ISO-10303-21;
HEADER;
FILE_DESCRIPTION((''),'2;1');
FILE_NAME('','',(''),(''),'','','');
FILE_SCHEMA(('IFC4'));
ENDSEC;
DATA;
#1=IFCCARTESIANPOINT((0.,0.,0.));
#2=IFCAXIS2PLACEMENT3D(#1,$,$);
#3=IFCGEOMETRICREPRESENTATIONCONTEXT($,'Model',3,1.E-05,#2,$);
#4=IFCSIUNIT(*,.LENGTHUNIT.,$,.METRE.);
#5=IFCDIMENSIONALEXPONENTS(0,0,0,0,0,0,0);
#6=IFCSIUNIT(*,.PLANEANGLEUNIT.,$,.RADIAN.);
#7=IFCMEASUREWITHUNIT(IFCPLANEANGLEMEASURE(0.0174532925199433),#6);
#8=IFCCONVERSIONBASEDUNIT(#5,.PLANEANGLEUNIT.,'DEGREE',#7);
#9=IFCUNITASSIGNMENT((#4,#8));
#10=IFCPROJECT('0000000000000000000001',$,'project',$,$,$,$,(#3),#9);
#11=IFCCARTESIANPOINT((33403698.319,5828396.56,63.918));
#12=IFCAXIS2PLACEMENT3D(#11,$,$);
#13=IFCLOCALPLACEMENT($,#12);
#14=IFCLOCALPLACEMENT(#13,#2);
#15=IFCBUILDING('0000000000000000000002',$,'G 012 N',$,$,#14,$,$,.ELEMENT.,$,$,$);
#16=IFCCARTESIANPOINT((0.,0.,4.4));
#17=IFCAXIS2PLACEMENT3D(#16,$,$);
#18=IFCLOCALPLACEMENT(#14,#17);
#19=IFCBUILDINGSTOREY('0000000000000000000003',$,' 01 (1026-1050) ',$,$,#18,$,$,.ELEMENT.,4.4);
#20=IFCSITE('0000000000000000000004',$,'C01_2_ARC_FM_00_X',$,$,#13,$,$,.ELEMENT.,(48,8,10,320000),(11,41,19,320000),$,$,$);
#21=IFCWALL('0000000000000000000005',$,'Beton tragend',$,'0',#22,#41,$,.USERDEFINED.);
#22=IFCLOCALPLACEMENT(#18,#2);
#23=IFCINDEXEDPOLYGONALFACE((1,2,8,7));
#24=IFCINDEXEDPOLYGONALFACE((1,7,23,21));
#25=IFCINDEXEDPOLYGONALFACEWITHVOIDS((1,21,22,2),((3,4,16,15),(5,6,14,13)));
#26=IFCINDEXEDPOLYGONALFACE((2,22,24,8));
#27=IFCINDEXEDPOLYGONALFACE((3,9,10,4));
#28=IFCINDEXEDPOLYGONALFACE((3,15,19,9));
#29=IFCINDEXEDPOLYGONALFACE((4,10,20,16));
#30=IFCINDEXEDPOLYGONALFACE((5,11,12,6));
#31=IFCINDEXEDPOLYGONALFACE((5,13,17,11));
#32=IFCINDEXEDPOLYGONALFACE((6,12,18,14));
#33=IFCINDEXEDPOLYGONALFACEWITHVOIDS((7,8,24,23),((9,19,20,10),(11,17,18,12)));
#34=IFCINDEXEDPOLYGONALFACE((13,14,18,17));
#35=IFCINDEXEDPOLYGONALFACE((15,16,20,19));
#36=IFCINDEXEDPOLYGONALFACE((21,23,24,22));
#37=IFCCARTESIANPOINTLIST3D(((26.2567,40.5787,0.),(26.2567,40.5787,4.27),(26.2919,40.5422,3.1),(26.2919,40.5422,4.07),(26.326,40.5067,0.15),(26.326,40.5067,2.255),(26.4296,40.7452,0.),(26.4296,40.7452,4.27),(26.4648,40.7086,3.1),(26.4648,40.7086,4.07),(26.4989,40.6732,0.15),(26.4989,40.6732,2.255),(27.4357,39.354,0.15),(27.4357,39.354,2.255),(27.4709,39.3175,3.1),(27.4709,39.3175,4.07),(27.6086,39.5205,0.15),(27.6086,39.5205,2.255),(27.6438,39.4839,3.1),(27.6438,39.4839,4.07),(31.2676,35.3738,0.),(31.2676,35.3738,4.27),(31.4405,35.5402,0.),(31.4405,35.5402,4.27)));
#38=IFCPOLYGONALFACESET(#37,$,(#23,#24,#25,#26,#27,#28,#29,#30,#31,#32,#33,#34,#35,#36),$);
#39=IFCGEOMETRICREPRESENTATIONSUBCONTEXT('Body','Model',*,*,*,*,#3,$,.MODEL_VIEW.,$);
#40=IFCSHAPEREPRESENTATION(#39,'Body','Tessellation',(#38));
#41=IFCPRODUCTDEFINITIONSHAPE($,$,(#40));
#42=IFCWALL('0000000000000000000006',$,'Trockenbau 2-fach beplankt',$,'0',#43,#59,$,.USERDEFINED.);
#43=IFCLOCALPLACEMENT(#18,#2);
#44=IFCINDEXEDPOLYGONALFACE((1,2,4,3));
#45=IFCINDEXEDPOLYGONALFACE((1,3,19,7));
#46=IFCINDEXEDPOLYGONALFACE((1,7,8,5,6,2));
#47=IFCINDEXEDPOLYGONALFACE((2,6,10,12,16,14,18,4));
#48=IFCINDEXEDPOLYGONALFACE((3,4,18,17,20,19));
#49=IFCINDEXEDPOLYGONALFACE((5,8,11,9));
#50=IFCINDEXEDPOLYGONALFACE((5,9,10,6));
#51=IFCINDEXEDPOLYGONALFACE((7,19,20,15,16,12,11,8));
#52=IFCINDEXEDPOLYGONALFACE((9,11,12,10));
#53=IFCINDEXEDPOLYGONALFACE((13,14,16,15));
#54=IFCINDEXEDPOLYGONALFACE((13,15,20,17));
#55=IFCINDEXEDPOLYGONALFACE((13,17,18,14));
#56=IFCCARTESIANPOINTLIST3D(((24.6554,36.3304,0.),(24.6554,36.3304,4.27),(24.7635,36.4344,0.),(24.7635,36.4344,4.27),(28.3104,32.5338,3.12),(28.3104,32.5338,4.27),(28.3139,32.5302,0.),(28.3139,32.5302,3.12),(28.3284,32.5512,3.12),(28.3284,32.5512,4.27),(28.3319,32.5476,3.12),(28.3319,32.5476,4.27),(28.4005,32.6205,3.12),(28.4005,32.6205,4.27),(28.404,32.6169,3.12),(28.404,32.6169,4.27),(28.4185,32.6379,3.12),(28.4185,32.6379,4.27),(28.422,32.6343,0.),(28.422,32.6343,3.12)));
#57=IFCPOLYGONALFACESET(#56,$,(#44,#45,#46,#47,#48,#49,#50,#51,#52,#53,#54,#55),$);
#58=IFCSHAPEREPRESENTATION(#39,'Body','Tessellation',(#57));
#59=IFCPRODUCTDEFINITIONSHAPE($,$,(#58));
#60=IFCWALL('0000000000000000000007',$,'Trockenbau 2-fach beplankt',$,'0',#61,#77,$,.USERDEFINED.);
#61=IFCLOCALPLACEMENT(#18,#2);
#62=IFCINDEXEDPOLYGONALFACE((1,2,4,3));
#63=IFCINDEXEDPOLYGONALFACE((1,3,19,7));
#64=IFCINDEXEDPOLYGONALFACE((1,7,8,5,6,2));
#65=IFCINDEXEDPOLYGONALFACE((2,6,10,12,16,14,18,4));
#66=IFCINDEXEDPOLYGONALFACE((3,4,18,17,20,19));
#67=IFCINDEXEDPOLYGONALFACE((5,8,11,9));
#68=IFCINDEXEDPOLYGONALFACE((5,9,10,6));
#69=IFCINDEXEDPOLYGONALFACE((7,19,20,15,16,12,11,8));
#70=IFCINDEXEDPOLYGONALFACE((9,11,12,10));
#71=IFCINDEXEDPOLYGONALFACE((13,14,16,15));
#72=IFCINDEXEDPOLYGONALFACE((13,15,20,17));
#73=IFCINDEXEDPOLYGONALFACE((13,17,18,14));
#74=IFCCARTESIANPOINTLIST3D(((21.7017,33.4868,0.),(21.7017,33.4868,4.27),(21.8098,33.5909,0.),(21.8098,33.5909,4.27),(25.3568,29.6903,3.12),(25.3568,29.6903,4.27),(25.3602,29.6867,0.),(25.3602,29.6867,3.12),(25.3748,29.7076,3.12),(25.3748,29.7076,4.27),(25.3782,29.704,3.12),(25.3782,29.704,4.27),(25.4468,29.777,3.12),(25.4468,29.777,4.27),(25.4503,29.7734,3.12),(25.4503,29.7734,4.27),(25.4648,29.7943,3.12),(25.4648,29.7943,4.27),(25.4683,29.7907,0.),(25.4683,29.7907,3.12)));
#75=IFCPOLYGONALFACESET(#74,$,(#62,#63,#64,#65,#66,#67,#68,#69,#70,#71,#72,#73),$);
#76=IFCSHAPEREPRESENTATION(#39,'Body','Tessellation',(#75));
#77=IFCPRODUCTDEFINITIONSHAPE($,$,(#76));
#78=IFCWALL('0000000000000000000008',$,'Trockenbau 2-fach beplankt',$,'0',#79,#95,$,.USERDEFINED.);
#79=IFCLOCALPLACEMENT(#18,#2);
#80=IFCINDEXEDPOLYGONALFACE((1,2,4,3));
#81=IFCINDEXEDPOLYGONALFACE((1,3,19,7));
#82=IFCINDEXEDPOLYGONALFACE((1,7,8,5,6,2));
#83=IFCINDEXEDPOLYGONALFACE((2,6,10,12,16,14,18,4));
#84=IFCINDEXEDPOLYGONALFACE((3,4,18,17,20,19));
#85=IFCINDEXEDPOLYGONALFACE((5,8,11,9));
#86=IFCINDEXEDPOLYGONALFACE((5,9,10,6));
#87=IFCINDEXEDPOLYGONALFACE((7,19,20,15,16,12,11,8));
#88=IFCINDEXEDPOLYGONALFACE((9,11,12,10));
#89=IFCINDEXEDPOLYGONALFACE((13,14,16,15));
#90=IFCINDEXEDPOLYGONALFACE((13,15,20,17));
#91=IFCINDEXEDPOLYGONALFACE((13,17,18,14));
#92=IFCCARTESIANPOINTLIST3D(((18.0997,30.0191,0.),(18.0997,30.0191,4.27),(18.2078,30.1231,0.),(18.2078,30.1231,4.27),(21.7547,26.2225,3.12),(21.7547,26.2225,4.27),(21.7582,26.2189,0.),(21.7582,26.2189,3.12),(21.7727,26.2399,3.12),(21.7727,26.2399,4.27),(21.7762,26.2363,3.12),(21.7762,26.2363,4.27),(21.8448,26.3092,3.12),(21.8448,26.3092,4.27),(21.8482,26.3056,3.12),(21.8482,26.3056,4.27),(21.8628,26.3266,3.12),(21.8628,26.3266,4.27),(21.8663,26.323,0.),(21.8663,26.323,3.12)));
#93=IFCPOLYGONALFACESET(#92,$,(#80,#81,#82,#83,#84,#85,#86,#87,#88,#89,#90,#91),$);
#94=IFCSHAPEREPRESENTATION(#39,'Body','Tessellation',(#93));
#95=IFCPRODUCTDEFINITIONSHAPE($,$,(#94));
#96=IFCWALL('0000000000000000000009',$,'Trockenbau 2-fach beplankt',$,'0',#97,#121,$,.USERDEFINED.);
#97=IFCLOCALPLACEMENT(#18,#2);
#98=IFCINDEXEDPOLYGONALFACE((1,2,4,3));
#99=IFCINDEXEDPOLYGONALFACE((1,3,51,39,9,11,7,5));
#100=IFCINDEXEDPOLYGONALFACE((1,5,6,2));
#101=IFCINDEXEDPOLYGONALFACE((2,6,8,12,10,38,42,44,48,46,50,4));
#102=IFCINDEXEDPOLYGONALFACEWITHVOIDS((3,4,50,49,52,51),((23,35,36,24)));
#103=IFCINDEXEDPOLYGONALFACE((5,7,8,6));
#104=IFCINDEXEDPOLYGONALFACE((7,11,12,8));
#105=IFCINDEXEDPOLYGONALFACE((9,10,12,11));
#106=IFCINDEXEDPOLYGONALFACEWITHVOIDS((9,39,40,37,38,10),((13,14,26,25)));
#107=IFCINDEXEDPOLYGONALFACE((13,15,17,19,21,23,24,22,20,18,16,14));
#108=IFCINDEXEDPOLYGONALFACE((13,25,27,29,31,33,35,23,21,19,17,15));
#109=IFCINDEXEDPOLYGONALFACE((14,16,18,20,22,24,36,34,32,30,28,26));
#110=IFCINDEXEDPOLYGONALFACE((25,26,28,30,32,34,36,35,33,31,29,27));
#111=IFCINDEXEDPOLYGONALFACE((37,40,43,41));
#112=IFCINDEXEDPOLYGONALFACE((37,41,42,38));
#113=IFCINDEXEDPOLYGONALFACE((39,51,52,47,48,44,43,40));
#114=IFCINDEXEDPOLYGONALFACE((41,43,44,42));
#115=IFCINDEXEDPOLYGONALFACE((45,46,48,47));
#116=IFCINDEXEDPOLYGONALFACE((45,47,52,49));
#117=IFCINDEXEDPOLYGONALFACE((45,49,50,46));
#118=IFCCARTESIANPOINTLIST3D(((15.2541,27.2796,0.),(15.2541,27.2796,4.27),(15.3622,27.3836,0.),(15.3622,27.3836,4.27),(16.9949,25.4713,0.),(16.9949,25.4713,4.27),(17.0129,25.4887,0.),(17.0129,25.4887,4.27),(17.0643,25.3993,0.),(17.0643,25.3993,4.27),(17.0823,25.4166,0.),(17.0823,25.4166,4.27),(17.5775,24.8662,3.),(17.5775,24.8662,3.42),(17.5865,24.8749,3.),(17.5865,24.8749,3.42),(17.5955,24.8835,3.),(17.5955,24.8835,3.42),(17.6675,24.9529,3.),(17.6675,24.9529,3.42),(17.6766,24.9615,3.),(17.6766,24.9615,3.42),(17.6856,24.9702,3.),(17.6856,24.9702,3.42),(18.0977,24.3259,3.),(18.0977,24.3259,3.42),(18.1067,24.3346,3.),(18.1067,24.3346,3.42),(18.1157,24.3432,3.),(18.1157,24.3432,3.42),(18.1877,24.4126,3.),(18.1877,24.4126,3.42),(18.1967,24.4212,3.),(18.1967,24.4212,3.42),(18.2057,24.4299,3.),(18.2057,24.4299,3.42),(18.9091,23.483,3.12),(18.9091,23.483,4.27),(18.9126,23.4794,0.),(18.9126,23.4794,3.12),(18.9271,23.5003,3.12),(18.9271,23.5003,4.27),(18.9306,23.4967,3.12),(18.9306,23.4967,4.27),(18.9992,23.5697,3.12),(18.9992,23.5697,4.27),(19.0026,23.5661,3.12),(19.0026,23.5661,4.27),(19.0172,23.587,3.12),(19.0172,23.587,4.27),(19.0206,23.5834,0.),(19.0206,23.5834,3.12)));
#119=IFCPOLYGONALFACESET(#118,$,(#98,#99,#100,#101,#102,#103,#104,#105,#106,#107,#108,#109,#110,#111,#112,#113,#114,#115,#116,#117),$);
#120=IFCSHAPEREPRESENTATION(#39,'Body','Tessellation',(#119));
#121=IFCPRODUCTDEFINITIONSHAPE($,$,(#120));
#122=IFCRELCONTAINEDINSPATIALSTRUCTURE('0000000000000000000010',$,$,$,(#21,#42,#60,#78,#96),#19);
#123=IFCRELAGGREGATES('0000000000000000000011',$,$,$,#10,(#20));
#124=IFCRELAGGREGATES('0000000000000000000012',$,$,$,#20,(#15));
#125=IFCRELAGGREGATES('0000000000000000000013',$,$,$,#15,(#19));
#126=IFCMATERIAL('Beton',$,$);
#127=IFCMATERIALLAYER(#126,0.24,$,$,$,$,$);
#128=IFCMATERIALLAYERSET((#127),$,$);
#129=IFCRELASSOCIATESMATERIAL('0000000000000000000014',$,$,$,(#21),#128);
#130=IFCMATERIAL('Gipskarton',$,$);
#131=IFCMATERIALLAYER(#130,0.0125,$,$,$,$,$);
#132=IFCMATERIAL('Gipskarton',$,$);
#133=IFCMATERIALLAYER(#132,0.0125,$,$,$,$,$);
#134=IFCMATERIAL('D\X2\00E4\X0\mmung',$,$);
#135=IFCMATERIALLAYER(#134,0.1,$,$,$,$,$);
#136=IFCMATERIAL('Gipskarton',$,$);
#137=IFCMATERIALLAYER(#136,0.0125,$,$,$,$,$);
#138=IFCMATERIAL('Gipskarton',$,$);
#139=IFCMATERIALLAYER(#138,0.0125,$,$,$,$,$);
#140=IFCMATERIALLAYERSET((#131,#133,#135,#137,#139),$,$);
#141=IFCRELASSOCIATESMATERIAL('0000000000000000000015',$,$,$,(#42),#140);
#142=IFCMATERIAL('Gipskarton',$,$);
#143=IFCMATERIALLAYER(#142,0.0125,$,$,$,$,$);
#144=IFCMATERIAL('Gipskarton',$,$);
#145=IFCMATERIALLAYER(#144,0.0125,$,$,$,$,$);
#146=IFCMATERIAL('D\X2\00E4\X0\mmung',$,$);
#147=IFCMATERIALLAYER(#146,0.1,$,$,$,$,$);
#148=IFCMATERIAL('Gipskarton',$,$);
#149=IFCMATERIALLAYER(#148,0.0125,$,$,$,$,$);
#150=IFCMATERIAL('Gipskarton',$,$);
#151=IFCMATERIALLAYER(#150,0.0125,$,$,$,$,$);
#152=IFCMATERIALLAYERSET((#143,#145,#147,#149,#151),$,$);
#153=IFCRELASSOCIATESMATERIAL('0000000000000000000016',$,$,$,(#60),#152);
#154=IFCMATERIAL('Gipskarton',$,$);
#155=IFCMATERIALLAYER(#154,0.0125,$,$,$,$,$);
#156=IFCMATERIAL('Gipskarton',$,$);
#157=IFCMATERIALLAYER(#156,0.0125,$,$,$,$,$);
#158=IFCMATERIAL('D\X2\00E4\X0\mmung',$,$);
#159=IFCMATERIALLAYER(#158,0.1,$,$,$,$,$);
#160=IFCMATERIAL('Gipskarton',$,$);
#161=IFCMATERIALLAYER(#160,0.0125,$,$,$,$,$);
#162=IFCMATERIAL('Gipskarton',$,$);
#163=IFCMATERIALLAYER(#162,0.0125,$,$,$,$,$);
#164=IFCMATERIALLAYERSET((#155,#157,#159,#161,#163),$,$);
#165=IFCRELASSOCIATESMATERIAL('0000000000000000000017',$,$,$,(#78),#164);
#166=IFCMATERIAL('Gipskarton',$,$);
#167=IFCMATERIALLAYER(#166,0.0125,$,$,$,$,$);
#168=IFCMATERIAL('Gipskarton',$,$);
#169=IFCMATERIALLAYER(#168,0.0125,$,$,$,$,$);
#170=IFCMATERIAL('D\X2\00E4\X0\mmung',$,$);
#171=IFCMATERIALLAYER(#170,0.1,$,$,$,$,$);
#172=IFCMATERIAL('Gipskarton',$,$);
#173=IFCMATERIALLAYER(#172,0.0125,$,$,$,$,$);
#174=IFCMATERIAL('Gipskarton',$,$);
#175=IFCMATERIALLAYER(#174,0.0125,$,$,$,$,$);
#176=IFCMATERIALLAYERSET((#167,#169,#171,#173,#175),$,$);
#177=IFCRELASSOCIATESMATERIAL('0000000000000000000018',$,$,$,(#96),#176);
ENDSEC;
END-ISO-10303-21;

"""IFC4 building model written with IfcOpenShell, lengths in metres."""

from ifc_helpers import new_model, entity, si_unit, converted_unit, frame, frame_2d, origin, origin_with_axes, place, context, subcontext, project, spatial, polyline, rectangle, outline, extrude, clip, bounded_halfspace, material, layer, layer_set, layer_usage, element, save


model = new_model("IFC4")

# Units and contexts
model_context = context("Model", 3, precision=1e-05, world=origin())
body_context = subcontext(model_context, "Body", "Model", "MODEL_VIEW")
ifc_project = project(units=[si_unit("LENGTHUNIT", "METRE"), converted_unit("PLANEANGLEUNIT", "DEGREE", entity("IfcPlaneAngleMeasure", 0.0174532925199433), si_unit("PLANEANGLEUNIT", "RADIAN"), dimensions=[0, 0, 0, 0, 0, 0, 0])], contexts=[model_context])

# Site, building, storey
site_placement = place(None, frame((33403698.319, 5828396.56, 63.918)))
site = spatial("IfcSite", under=ifc_project, at=site_placement, Name="C01_2_ARC_FM_00_X", CompositionType="ELEMENT", RefLatitude=(48, 8, 10, 320000), RefLongitude=(11, 41, 19, 320000))
building_placement = place(site_placement, origin())
building = spatial("IfcBuilding", under=site, at=building_placement, Name="G 012 N", CompositionType="ELEMENT")
storey_placement = place(building_placement, frame((0.0, 0.0, 4.4)))
storey = spatial("IfcBuildingStorey", under=building, at=storey_placement, Name=" 01 (1026-1050) ", CompositionType="ELEMENT", Elevation=4.4)

# Wall, openings
ifc_material_1 = material(Name="Beton")
ifc_layer_1 = layer(ifc_material_1, 0.24)
ifc_layer_set_1 = layer_set([ifc_layer_1])
ifc_layer_usage_1 = layer_usage(ifc_layer_set_1, "AXIS2", "POSITIVE", 0.0)
wall_1_placement = place(storey_placement, frame((31.4405, 35.5402, 0.0), z_axis=(0.0, 0.0, 1.0), x_axis=(-0.693551, 0.720408, 0.0)))
wall_1 = element("IfcWall", 1, at=wall_1_placement, inside=storey, material=ifc_layer_usage_1, Name="Beton tragend", ObjectType="0", PredefinedType="USERDEFINED", context=body_context, shape_type="SweptSolid", body=[
    extrude(rectangle(XDim=7.225, YDim=0.24, at=frame_2d((3.6125, 0.12), x_axis=(1.0, 0.0))), origin_with_axes(), (0.0, 0.0, 1.0), 4.27),
])
opening_1_placement = place(wall_1_placement, frame((5.525, 0.0, 0.15), z_axis=(0.0, 1.0, 0.0), x_axis=(0.0, 0.0, 1.0)))
element("IfcOpeningElement", 2, at=opening_1_placement, cuts=wall_1, ObjectType="Opening", context=body_context, shape_type="SweptSolid", body=[
    extrude(outline(polyline([(0.0, 1.6), (2.105, 1.6), (2.105, 0.0), (0.0, 0.0), (0.0, 1.6)])), origin_with_axes(), (0.0, 0.0, 1.0), 0.24),
])
opening_2_placement = place(wall_1_placement, frame((5.4742, 0.0, 3.1), z_axis=(0.0, 1.0, 0.0), x_axis=(0.0, 0.0, 1.0)))
element("IfcOpeningElement", 3, at=opening_2_placement, cuts=wall_1, ObjectType="0", PredefinedType="USERDEFINED", context=body_context, shape_type="SweptSolid", body=[
    extrude(outline(polyline([(0.0, 1.7), (0.97, 1.7), (0.97, 0.0), (0.0, 0.0), (0.0, 1.7)])), origin_with_axes(), (0.0, 0.0, 1.0), 0.24),
])

# Walls
ifc_material_2 = material(Name="Gipskarton")
ifc_layer_2 = layer(ifc_material_2, 0.0125)
ifc_material_3 = material(Name="Gipskarton")
ifc_layer_3 = layer(ifc_material_3, 0.0125)
ifc_material_4 = material(Name="Dämmung")
ifc_layer_4 = layer(ifc_material_4, 0.1)
ifc_material_5 = material(Name="Gipskarton")
ifc_layer_5 = layer(ifc_material_5, 0.0125)
ifc_material_6 = material(Name="Gipskarton")
ifc_layer_6 = layer(ifc_material_6, 0.0125)
ifc_layer_set_2 = layer_set([ifc_layer_2, ifc_layer_3, ifc_layer_4, ifc_layer_5, ifc_layer_6])
ifc_layer_usage_2 = layer_usage(ifc_layer_set_2, "AXIS2", "POSITIVE", 0.0)
wall_2_placement = place(storey_placement, frame((28.422, 32.6343, 0.0), z_axis=(0.0, 0.0, 1.0), x_axis=(-0.693551, 0.720408, 0.0)))
element("IfcWall", 4, at=wall_2_placement, inside=storey, material=ifc_layer_usage_2, Name="Trockenbau 2-fach beplankt", ObjectType="0", PredefinedType="USERDEFINED", context=body_context, shape_type="Clipping", body=[
    clip(clip(extrude(rectangle(XDim=5.275, YDim=0.15, at=frame_2d((2.6375, 0.075), x_axis=(1.0, 0.0))), origin_with_axes(), (0.0, 0.0, 1.0), 4.27), bounded_halfspace(frame((0.0025, 0.1375, 3.12), z_axis=(0.0, 0.0, -1.0), x_axis=(0.0, -1.0, 0.0)), True, origin_with_axes(), polyline([(0.0, 0.15), (0.0, 0.125), (0.005, 0.125), (0.005, 0.15), (0.0, 0.15)]))), bounded_halfspace(frame((0.0025, 0.0125, 3.12), z_axis=(0.0, 0.0, -1.0), x_axis=(0.0, -1.0, 0.0)), True, origin_with_axes(), polyline([(0.0, 0.025), (0.0, 0.0), (0.005, 0.0), (0.005, 0.025), (0.0, 0.025)]))),
])
ifc_material_7 = material(Name="Gipskarton")
ifc_layer_7 = layer(ifc_material_7, 0.0125)
ifc_material_8 = material(Name="Gipskarton")
ifc_layer_8 = layer(ifc_material_8, 0.0125)
ifc_material_9 = material(Name="Dämmung")
ifc_layer_9 = layer(ifc_material_9, 0.1)
ifc_material_10 = material(Name="Gipskarton")
ifc_layer_10 = layer(ifc_material_10, 0.0125)
ifc_material_11 = material(Name="Gipskarton")
ifc_layer_11 = layer(ifc_material_11, 0.0125)
ifc_layer_set_3 = layer_set([ifc_layer_7, ifc_layer_8, ifc_layer_9, ifc_layer_10, ifc_layer_11])
ifc_layer_usage_3 = layer_usage(ifc_layer_set_3, "AXIS2", "POSITIVE", 0.0)
wall_3_placement = place(storey_placement, frame((25.4683, 29.7907, 0.0), z_axis=(0.0, 0.0, 1.0), x_axis=(-0.693551, 0.720408, 0.0)))
element("IfcWall", 5, at=wall_3_placement, inside=storey, material=ifc_layer_usage_3, Name="Trockenbau 2-fach beplankt", ObjectType="0", PredefinedType="USERDEFINED", context=body_context, shape_type="Clipping", body=[
    clip(clip(extrude(rectangle(XDim=5.275, YDim=0.15, at=frame_2d((2.6375, 0.075), x_axis=(1.0, 0.0))), origin_with_axes(), (0.0, 0.0, 1.0), 4.27), bounded_halfspace(frame((0.0025, 0.1375, 3.12), z_axis=(0.0, 0.0, -1.0), x_axis=(0.0, -1.0, 0.0)), True, origin_with_axes(), polyline([(0.0, 0.15), (0.0, 0.125), (0.005, 0.125), (0.005, 0.15), (0.0, 0.15)]))), bounded_halfspace(frame((0.0025, 0.0125, 3.12), z_axis=(0.0, 0.0, -1.0), x_axis=(0.0, -1.0, 0.0)), True, origin_with_axes(), polyline([(0.0, 0.025), (0.0, 0.0), (0.005, 0.0), (0.005, 0.025), (0.0, 0.025)]))),
])
ifc_material_12 = material(Name="Gipskarton")
ifc_layer_12 = layer(ifc_material_12, 0.0125)
ifc_material_13 = material(Name="Gipskarton")
ifc_layer_13 = layer(ifc_material_13, 0.0125)
ifc_material_14 = material(Name="Dämmung")
ifc_layer_14 = layer(ifc_material_14, 0.1)
ifc_material_15 = material(Name="Gipskarton")
ifc_layer_15 = layer(ifc_material_15, 0.0125)
ifc_material_16 = material(Name="Gipskarton")
ifc_layer_16 = layer(ifc_material_16, 0.0125)
ifc_layer_set_4 = layer_set([ifc_layer_12, ifc_layer_13, ifc_layer_14, ifc_layer_15, ifc_layer_16])
ifc_layer_usage_4 = layer_usage(ifc_layer_set_4, "AXIS2", "POSITIVE", 0.0)
wall_4_placement = place(storey_placement, frame((21.8663, 26.323, 0.0), z_axis=(0.0, 0.0, 1.0), x_axis=(-0.693551, 0.720408, 0.0)))
element("IfcWall", 6, at=wall_4_placement, inside=storey, material=ifc_layer_usage_4, Name="Trockenbau 2-fach beplankt", ObjectType="0", PredefinedType="USERDEFINED", context=body_context, shape_type="Clipping", body=[
    clip(clip(extrude(rectangle(XDim=5.275, YDim=0.15, at=frame_2d((2.6375, 0.075), x_axis=(1.0, 0.0))), origin_with_axes(), (0.0, 0.0, 1.0), 4.27), bounded_halfspace(frame((0.0025, 0.1375, 3.12), z_axis=(0.0, 0.0, -1.0), x_axis=(0.0, -1.0, 0.0)), True, origin_with_axes(), polyline([(0.0, 0.15), (0.0, 0.125), (0.005, 0.125), (0.005, 0.15), (0.0, 0.15)]))), bounded_halfspace(frame((0.0025, 0.0125, 3.12), z_axis=(0.0, 0.0, -1.0), x_axis=(0.0, -1.0, 0.0)), True, origin_with_axes(), polyline([(0.0, 0.025), (0.0, 0.0), (0.005, 0.0), (0.005, 0.025), (0.0, 0.025)]))),
])

# Wall, opening
ifc_material_17 = material(Name="Gipskarton")
ifc_layer_17 = layer(ifc_material_17, 0.0125)
ifc_material_18 = material(Name="Gipskarton")
ifc_layer_18 = layer(ifc_material_18, 0.0125)
ifc_material_19 = material(Name="Dämmung")
ifc_layer_19 = layer(ifc_material_19, 0.1)
ifc_material_20 = material(Name="Gipskarton")
ifc_layer_20 = layer(ifc_material_20, 0.0125)
ifc_material_21 = material(Name="Gipskarton")
ifc_layer_21 = layer(ifc_material_21, 0.0125)
ifc_layer_set_5 = layer_set([ifc_layer_17, ifc_layer_18, ifc_layer_19, ifc_layer_20, ifc_layer_21])
ifc_layer_usage_5 = layer_usage(ifc_layer_set_5, "AXIS2", "POSITIVE", 0.0)
wall_5_placement = place(storey_placement, frame((19.0206, 23.5834, 0.0), z_axis=(0.0, 0.0, 1.0), x_axis=(-0.693551, 0.720408, 0.0)))
wall_5 = element("IfcWall", 7, at=wall_5_placement, inside=storey, material=ifc_layer_usage_5, Name="Trockenbau 2-fach beplankt", ObjectType="0", PredefinedType="USERDEFINED", context=body_context, shape_type="Clipping", body=[
    clip(clip(extrude(outline(polyline([(0.2277, -2.6356), (0.2277, -2.6606), (0.1277, -2.6606), (0.1277, -2.6356), (-2.5373, -2.6356), (-2.5373, -2.7856), (2.7377, -2.7856), (2.7377, -2.6356), (0.2277, -2.6356)])), frame((2.5373, 2.7856, 0.0), z_axis=(0.0, 0.0, 1.0), x_axis=(1.0, 0.0, 0.0)), (0.0, 0.0, 1.0), 4.27), bounded_halfspace(frame((0.0025, 0.1375, 3.12), z_axis=(0.0, 0.0, -1.0), x_axis=(0.0, -1.0, 0.0)), True, origin_with_axes(), polyline([(0.0, 0.15), (0.0, 0.125), (0.005, 0.125), (0.005, 0.15), (0.0, 0.15)]))), bounded_halfspace(frame((0.0025, 0.0125, 3.12), z_axis=(0.0, 0.0, -1.0), x_axis=(0.0, -1.0, 0.0)), True, origin_with_axes(), polyline([(0.0, 0.025), (0.0, 0.0), (0.005, 0.0), (0.005, 0.025), (0.0, 0.025)]))),
])
opening_3_placement = place(wall_5_placement, frame((1.925, 0.15, 3.0), z_axis=(0.0, -1.0, 0.0), x_axis=(0.0, 0.0, 1.0)))
element("IfcOpeningElement", 8, at=opening_3_placement, cuts=wall_5, ObjectType="0", PredefinedType="USERDEFINED", context=body_context, shape_type="SweptSolid", body=[
    extrude(outline(polyline([(0.0, 0.75), (0.42, 0.75), (0.42, 0.0), (0.0, 0.0), (0.0, 0.75)])), origin_with_axes(), (0.0, 0.0, 1.0), 0.0125),
    extrude(outline(polyline([(0.0, 0.75), (0.42, 0.75), (0.42, 0.0), (0.0, 0.0), (0.0, 0.75)])), frame((0.0, 0.0, 0.0125), z_axis=(0.0, 0.0, 1.0), x_axis=(1.0, 0.0, 0.0)), (0.0, 0.0, 1.0), 0.0125),
    extrude(outline(polyline([(0.0, 0.75), (0.42, 0.75), (0.42, 0.0), (0.0, 0.0), (0.0, 0.75)])), frame((0.0, 0.0, 0.025), z_axis=(0.0, 0.0, 1.0), x_axis=(1.0, 0.0, 0.0)), (0.0, 0.0, 1.0), 0.1),
    extrude(outline(polyline([(0.0, 0.75), (0.42, 0.75), (0.42, 0.0), (0.0, 0.0), (0.0, 0.75)])), frame((0.0, 0.0, 0.125), z_axis=(0.0, 0.0, 1.0), x_axis=(1.0, 0.0, 0.0)), (0.0, 0.0, 1.0), 0.0125),
    extrude(outline(polyline([(0.0, 0.75), (0.42, 0.75), (0.42, 0.0), (0.0, 0.0), (0.0, 0.75)])), frame((0.0, 0.0, 0.1375), z_axis=(0.0, 0.0, 1.0), x_axis=(1.0, 0.0, 0.0)), (0.0, 0.0, 1.0), 0.0125),
])

save(model, "model.ifc")
